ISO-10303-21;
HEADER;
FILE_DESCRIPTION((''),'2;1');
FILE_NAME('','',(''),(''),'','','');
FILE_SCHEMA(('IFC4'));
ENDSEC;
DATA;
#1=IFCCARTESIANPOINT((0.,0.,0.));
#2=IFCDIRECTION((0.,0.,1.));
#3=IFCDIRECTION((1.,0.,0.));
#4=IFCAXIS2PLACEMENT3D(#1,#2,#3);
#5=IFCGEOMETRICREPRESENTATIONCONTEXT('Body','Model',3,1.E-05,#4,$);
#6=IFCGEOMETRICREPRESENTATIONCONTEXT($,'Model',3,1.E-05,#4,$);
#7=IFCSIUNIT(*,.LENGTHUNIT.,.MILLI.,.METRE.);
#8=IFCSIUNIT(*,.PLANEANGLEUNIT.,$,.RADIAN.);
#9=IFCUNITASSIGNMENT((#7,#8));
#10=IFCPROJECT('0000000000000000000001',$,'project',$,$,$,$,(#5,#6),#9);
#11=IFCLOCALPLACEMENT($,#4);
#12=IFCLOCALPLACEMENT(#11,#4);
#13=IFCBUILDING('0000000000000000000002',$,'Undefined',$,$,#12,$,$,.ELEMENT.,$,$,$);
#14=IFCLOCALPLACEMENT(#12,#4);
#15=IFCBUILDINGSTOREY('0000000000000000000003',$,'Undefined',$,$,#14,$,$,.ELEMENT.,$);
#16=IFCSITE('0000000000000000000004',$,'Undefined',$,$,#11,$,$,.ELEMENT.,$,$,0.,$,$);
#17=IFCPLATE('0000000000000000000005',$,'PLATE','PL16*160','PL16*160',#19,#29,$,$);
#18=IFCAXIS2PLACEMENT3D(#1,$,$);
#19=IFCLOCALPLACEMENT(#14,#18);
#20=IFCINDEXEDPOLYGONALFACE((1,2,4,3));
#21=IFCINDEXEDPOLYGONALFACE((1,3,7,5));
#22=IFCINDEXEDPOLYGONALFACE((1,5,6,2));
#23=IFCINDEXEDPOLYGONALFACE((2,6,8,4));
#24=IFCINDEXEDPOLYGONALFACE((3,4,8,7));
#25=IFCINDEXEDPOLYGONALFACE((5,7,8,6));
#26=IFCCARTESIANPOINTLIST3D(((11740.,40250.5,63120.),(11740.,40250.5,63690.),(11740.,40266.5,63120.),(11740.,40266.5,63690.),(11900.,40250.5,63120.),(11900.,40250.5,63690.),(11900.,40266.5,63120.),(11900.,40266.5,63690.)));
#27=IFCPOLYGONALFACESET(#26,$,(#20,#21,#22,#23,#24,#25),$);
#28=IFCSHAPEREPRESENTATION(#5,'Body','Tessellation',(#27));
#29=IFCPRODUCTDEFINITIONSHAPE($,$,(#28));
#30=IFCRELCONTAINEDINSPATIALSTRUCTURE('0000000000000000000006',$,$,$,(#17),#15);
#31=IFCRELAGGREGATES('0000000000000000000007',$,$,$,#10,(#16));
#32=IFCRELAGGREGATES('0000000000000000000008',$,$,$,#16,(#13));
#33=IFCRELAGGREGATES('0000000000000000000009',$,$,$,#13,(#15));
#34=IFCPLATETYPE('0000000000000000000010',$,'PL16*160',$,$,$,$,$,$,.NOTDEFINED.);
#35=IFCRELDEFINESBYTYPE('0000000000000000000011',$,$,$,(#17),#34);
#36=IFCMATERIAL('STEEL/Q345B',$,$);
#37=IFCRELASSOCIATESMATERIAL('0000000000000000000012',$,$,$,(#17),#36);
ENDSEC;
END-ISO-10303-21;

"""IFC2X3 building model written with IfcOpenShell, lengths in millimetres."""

from ifc_helpers import new_model, si_unit, frame, origin_with_axes, place, context, project, spatial, polyline, outline, extrude, material, type_object, element, save


model = new_model("IFC2X3")

# Units and contexts
model_context_1 = context("Model", 3, precision=1e-05, world=origin_with_axes(), identifier="Body")
model_context_2 = context("Model", 3, precision=1e-05, world=origin_with_axes())
ifc_project = project(units=[si_unit("LENGTHUNIT", "METRE", prefix="MILLI"), si_unit("PLANEANGLEUNIT", "RADIAN")], contexts=[model_context_1, model_context_2])

# Site, building, storey
site_placement = place(None, origin_with_axes())
site = spatial("IfcSite", under=ifc_project, at=site_placement, Name="Undefined", CompositionType="ELEMENT", RefElevation=0.0)
building_placement = place(site_placement, origin_with_axes())
building = spatial("IfcBuilding", under=site, at=building_placement, Name="Undefined", CompositionType="ELEMENT")
storey_placement = place(building_placement, origin_with_axes())
storey = spatial("IfcBuildingStorey", under=building, at=storey_placement, Name="Undefined", CompositionType="ELEMENT")

# Shared definitions
ifc_material_1 = material(Name="STEEL/Q345B")

# Plate
plate_type_1 = type_object("IfcPlateType", Name="PL16*160", PredefinedType="NOTDEFINED")
plate_1_placement = place(storey_placement, frame((11740.0, 40258.5, 63690.0), z_axis=(0.0, 1.0, 0.0), x_axis=(1.0, 0.0, 0.0)))
element("IfcPlate", 1, at=plate_1_placement, inside=storey, type_object=plate_type_1, material=ifc_material_1, Name="PLATE", Description="PL16*160", ObjectType="PL16*160", context=model_context_1, shape_type="SweptSolid", body=[
    extrude(outline(polyline([(0.0, 0.0), (160.0, 0.0), (160.0, 570.0), (0.0, 570.0), (0.0, 0.0)])), frame((0.0, 0.0, -8.0), z_axis=(0.0, 0.0, 1.0), x_axis=(1.0, 0.0, 0.0)), (0.0, 0.0, 1.0), 16.0),
])

save(model, "model.ifc")
